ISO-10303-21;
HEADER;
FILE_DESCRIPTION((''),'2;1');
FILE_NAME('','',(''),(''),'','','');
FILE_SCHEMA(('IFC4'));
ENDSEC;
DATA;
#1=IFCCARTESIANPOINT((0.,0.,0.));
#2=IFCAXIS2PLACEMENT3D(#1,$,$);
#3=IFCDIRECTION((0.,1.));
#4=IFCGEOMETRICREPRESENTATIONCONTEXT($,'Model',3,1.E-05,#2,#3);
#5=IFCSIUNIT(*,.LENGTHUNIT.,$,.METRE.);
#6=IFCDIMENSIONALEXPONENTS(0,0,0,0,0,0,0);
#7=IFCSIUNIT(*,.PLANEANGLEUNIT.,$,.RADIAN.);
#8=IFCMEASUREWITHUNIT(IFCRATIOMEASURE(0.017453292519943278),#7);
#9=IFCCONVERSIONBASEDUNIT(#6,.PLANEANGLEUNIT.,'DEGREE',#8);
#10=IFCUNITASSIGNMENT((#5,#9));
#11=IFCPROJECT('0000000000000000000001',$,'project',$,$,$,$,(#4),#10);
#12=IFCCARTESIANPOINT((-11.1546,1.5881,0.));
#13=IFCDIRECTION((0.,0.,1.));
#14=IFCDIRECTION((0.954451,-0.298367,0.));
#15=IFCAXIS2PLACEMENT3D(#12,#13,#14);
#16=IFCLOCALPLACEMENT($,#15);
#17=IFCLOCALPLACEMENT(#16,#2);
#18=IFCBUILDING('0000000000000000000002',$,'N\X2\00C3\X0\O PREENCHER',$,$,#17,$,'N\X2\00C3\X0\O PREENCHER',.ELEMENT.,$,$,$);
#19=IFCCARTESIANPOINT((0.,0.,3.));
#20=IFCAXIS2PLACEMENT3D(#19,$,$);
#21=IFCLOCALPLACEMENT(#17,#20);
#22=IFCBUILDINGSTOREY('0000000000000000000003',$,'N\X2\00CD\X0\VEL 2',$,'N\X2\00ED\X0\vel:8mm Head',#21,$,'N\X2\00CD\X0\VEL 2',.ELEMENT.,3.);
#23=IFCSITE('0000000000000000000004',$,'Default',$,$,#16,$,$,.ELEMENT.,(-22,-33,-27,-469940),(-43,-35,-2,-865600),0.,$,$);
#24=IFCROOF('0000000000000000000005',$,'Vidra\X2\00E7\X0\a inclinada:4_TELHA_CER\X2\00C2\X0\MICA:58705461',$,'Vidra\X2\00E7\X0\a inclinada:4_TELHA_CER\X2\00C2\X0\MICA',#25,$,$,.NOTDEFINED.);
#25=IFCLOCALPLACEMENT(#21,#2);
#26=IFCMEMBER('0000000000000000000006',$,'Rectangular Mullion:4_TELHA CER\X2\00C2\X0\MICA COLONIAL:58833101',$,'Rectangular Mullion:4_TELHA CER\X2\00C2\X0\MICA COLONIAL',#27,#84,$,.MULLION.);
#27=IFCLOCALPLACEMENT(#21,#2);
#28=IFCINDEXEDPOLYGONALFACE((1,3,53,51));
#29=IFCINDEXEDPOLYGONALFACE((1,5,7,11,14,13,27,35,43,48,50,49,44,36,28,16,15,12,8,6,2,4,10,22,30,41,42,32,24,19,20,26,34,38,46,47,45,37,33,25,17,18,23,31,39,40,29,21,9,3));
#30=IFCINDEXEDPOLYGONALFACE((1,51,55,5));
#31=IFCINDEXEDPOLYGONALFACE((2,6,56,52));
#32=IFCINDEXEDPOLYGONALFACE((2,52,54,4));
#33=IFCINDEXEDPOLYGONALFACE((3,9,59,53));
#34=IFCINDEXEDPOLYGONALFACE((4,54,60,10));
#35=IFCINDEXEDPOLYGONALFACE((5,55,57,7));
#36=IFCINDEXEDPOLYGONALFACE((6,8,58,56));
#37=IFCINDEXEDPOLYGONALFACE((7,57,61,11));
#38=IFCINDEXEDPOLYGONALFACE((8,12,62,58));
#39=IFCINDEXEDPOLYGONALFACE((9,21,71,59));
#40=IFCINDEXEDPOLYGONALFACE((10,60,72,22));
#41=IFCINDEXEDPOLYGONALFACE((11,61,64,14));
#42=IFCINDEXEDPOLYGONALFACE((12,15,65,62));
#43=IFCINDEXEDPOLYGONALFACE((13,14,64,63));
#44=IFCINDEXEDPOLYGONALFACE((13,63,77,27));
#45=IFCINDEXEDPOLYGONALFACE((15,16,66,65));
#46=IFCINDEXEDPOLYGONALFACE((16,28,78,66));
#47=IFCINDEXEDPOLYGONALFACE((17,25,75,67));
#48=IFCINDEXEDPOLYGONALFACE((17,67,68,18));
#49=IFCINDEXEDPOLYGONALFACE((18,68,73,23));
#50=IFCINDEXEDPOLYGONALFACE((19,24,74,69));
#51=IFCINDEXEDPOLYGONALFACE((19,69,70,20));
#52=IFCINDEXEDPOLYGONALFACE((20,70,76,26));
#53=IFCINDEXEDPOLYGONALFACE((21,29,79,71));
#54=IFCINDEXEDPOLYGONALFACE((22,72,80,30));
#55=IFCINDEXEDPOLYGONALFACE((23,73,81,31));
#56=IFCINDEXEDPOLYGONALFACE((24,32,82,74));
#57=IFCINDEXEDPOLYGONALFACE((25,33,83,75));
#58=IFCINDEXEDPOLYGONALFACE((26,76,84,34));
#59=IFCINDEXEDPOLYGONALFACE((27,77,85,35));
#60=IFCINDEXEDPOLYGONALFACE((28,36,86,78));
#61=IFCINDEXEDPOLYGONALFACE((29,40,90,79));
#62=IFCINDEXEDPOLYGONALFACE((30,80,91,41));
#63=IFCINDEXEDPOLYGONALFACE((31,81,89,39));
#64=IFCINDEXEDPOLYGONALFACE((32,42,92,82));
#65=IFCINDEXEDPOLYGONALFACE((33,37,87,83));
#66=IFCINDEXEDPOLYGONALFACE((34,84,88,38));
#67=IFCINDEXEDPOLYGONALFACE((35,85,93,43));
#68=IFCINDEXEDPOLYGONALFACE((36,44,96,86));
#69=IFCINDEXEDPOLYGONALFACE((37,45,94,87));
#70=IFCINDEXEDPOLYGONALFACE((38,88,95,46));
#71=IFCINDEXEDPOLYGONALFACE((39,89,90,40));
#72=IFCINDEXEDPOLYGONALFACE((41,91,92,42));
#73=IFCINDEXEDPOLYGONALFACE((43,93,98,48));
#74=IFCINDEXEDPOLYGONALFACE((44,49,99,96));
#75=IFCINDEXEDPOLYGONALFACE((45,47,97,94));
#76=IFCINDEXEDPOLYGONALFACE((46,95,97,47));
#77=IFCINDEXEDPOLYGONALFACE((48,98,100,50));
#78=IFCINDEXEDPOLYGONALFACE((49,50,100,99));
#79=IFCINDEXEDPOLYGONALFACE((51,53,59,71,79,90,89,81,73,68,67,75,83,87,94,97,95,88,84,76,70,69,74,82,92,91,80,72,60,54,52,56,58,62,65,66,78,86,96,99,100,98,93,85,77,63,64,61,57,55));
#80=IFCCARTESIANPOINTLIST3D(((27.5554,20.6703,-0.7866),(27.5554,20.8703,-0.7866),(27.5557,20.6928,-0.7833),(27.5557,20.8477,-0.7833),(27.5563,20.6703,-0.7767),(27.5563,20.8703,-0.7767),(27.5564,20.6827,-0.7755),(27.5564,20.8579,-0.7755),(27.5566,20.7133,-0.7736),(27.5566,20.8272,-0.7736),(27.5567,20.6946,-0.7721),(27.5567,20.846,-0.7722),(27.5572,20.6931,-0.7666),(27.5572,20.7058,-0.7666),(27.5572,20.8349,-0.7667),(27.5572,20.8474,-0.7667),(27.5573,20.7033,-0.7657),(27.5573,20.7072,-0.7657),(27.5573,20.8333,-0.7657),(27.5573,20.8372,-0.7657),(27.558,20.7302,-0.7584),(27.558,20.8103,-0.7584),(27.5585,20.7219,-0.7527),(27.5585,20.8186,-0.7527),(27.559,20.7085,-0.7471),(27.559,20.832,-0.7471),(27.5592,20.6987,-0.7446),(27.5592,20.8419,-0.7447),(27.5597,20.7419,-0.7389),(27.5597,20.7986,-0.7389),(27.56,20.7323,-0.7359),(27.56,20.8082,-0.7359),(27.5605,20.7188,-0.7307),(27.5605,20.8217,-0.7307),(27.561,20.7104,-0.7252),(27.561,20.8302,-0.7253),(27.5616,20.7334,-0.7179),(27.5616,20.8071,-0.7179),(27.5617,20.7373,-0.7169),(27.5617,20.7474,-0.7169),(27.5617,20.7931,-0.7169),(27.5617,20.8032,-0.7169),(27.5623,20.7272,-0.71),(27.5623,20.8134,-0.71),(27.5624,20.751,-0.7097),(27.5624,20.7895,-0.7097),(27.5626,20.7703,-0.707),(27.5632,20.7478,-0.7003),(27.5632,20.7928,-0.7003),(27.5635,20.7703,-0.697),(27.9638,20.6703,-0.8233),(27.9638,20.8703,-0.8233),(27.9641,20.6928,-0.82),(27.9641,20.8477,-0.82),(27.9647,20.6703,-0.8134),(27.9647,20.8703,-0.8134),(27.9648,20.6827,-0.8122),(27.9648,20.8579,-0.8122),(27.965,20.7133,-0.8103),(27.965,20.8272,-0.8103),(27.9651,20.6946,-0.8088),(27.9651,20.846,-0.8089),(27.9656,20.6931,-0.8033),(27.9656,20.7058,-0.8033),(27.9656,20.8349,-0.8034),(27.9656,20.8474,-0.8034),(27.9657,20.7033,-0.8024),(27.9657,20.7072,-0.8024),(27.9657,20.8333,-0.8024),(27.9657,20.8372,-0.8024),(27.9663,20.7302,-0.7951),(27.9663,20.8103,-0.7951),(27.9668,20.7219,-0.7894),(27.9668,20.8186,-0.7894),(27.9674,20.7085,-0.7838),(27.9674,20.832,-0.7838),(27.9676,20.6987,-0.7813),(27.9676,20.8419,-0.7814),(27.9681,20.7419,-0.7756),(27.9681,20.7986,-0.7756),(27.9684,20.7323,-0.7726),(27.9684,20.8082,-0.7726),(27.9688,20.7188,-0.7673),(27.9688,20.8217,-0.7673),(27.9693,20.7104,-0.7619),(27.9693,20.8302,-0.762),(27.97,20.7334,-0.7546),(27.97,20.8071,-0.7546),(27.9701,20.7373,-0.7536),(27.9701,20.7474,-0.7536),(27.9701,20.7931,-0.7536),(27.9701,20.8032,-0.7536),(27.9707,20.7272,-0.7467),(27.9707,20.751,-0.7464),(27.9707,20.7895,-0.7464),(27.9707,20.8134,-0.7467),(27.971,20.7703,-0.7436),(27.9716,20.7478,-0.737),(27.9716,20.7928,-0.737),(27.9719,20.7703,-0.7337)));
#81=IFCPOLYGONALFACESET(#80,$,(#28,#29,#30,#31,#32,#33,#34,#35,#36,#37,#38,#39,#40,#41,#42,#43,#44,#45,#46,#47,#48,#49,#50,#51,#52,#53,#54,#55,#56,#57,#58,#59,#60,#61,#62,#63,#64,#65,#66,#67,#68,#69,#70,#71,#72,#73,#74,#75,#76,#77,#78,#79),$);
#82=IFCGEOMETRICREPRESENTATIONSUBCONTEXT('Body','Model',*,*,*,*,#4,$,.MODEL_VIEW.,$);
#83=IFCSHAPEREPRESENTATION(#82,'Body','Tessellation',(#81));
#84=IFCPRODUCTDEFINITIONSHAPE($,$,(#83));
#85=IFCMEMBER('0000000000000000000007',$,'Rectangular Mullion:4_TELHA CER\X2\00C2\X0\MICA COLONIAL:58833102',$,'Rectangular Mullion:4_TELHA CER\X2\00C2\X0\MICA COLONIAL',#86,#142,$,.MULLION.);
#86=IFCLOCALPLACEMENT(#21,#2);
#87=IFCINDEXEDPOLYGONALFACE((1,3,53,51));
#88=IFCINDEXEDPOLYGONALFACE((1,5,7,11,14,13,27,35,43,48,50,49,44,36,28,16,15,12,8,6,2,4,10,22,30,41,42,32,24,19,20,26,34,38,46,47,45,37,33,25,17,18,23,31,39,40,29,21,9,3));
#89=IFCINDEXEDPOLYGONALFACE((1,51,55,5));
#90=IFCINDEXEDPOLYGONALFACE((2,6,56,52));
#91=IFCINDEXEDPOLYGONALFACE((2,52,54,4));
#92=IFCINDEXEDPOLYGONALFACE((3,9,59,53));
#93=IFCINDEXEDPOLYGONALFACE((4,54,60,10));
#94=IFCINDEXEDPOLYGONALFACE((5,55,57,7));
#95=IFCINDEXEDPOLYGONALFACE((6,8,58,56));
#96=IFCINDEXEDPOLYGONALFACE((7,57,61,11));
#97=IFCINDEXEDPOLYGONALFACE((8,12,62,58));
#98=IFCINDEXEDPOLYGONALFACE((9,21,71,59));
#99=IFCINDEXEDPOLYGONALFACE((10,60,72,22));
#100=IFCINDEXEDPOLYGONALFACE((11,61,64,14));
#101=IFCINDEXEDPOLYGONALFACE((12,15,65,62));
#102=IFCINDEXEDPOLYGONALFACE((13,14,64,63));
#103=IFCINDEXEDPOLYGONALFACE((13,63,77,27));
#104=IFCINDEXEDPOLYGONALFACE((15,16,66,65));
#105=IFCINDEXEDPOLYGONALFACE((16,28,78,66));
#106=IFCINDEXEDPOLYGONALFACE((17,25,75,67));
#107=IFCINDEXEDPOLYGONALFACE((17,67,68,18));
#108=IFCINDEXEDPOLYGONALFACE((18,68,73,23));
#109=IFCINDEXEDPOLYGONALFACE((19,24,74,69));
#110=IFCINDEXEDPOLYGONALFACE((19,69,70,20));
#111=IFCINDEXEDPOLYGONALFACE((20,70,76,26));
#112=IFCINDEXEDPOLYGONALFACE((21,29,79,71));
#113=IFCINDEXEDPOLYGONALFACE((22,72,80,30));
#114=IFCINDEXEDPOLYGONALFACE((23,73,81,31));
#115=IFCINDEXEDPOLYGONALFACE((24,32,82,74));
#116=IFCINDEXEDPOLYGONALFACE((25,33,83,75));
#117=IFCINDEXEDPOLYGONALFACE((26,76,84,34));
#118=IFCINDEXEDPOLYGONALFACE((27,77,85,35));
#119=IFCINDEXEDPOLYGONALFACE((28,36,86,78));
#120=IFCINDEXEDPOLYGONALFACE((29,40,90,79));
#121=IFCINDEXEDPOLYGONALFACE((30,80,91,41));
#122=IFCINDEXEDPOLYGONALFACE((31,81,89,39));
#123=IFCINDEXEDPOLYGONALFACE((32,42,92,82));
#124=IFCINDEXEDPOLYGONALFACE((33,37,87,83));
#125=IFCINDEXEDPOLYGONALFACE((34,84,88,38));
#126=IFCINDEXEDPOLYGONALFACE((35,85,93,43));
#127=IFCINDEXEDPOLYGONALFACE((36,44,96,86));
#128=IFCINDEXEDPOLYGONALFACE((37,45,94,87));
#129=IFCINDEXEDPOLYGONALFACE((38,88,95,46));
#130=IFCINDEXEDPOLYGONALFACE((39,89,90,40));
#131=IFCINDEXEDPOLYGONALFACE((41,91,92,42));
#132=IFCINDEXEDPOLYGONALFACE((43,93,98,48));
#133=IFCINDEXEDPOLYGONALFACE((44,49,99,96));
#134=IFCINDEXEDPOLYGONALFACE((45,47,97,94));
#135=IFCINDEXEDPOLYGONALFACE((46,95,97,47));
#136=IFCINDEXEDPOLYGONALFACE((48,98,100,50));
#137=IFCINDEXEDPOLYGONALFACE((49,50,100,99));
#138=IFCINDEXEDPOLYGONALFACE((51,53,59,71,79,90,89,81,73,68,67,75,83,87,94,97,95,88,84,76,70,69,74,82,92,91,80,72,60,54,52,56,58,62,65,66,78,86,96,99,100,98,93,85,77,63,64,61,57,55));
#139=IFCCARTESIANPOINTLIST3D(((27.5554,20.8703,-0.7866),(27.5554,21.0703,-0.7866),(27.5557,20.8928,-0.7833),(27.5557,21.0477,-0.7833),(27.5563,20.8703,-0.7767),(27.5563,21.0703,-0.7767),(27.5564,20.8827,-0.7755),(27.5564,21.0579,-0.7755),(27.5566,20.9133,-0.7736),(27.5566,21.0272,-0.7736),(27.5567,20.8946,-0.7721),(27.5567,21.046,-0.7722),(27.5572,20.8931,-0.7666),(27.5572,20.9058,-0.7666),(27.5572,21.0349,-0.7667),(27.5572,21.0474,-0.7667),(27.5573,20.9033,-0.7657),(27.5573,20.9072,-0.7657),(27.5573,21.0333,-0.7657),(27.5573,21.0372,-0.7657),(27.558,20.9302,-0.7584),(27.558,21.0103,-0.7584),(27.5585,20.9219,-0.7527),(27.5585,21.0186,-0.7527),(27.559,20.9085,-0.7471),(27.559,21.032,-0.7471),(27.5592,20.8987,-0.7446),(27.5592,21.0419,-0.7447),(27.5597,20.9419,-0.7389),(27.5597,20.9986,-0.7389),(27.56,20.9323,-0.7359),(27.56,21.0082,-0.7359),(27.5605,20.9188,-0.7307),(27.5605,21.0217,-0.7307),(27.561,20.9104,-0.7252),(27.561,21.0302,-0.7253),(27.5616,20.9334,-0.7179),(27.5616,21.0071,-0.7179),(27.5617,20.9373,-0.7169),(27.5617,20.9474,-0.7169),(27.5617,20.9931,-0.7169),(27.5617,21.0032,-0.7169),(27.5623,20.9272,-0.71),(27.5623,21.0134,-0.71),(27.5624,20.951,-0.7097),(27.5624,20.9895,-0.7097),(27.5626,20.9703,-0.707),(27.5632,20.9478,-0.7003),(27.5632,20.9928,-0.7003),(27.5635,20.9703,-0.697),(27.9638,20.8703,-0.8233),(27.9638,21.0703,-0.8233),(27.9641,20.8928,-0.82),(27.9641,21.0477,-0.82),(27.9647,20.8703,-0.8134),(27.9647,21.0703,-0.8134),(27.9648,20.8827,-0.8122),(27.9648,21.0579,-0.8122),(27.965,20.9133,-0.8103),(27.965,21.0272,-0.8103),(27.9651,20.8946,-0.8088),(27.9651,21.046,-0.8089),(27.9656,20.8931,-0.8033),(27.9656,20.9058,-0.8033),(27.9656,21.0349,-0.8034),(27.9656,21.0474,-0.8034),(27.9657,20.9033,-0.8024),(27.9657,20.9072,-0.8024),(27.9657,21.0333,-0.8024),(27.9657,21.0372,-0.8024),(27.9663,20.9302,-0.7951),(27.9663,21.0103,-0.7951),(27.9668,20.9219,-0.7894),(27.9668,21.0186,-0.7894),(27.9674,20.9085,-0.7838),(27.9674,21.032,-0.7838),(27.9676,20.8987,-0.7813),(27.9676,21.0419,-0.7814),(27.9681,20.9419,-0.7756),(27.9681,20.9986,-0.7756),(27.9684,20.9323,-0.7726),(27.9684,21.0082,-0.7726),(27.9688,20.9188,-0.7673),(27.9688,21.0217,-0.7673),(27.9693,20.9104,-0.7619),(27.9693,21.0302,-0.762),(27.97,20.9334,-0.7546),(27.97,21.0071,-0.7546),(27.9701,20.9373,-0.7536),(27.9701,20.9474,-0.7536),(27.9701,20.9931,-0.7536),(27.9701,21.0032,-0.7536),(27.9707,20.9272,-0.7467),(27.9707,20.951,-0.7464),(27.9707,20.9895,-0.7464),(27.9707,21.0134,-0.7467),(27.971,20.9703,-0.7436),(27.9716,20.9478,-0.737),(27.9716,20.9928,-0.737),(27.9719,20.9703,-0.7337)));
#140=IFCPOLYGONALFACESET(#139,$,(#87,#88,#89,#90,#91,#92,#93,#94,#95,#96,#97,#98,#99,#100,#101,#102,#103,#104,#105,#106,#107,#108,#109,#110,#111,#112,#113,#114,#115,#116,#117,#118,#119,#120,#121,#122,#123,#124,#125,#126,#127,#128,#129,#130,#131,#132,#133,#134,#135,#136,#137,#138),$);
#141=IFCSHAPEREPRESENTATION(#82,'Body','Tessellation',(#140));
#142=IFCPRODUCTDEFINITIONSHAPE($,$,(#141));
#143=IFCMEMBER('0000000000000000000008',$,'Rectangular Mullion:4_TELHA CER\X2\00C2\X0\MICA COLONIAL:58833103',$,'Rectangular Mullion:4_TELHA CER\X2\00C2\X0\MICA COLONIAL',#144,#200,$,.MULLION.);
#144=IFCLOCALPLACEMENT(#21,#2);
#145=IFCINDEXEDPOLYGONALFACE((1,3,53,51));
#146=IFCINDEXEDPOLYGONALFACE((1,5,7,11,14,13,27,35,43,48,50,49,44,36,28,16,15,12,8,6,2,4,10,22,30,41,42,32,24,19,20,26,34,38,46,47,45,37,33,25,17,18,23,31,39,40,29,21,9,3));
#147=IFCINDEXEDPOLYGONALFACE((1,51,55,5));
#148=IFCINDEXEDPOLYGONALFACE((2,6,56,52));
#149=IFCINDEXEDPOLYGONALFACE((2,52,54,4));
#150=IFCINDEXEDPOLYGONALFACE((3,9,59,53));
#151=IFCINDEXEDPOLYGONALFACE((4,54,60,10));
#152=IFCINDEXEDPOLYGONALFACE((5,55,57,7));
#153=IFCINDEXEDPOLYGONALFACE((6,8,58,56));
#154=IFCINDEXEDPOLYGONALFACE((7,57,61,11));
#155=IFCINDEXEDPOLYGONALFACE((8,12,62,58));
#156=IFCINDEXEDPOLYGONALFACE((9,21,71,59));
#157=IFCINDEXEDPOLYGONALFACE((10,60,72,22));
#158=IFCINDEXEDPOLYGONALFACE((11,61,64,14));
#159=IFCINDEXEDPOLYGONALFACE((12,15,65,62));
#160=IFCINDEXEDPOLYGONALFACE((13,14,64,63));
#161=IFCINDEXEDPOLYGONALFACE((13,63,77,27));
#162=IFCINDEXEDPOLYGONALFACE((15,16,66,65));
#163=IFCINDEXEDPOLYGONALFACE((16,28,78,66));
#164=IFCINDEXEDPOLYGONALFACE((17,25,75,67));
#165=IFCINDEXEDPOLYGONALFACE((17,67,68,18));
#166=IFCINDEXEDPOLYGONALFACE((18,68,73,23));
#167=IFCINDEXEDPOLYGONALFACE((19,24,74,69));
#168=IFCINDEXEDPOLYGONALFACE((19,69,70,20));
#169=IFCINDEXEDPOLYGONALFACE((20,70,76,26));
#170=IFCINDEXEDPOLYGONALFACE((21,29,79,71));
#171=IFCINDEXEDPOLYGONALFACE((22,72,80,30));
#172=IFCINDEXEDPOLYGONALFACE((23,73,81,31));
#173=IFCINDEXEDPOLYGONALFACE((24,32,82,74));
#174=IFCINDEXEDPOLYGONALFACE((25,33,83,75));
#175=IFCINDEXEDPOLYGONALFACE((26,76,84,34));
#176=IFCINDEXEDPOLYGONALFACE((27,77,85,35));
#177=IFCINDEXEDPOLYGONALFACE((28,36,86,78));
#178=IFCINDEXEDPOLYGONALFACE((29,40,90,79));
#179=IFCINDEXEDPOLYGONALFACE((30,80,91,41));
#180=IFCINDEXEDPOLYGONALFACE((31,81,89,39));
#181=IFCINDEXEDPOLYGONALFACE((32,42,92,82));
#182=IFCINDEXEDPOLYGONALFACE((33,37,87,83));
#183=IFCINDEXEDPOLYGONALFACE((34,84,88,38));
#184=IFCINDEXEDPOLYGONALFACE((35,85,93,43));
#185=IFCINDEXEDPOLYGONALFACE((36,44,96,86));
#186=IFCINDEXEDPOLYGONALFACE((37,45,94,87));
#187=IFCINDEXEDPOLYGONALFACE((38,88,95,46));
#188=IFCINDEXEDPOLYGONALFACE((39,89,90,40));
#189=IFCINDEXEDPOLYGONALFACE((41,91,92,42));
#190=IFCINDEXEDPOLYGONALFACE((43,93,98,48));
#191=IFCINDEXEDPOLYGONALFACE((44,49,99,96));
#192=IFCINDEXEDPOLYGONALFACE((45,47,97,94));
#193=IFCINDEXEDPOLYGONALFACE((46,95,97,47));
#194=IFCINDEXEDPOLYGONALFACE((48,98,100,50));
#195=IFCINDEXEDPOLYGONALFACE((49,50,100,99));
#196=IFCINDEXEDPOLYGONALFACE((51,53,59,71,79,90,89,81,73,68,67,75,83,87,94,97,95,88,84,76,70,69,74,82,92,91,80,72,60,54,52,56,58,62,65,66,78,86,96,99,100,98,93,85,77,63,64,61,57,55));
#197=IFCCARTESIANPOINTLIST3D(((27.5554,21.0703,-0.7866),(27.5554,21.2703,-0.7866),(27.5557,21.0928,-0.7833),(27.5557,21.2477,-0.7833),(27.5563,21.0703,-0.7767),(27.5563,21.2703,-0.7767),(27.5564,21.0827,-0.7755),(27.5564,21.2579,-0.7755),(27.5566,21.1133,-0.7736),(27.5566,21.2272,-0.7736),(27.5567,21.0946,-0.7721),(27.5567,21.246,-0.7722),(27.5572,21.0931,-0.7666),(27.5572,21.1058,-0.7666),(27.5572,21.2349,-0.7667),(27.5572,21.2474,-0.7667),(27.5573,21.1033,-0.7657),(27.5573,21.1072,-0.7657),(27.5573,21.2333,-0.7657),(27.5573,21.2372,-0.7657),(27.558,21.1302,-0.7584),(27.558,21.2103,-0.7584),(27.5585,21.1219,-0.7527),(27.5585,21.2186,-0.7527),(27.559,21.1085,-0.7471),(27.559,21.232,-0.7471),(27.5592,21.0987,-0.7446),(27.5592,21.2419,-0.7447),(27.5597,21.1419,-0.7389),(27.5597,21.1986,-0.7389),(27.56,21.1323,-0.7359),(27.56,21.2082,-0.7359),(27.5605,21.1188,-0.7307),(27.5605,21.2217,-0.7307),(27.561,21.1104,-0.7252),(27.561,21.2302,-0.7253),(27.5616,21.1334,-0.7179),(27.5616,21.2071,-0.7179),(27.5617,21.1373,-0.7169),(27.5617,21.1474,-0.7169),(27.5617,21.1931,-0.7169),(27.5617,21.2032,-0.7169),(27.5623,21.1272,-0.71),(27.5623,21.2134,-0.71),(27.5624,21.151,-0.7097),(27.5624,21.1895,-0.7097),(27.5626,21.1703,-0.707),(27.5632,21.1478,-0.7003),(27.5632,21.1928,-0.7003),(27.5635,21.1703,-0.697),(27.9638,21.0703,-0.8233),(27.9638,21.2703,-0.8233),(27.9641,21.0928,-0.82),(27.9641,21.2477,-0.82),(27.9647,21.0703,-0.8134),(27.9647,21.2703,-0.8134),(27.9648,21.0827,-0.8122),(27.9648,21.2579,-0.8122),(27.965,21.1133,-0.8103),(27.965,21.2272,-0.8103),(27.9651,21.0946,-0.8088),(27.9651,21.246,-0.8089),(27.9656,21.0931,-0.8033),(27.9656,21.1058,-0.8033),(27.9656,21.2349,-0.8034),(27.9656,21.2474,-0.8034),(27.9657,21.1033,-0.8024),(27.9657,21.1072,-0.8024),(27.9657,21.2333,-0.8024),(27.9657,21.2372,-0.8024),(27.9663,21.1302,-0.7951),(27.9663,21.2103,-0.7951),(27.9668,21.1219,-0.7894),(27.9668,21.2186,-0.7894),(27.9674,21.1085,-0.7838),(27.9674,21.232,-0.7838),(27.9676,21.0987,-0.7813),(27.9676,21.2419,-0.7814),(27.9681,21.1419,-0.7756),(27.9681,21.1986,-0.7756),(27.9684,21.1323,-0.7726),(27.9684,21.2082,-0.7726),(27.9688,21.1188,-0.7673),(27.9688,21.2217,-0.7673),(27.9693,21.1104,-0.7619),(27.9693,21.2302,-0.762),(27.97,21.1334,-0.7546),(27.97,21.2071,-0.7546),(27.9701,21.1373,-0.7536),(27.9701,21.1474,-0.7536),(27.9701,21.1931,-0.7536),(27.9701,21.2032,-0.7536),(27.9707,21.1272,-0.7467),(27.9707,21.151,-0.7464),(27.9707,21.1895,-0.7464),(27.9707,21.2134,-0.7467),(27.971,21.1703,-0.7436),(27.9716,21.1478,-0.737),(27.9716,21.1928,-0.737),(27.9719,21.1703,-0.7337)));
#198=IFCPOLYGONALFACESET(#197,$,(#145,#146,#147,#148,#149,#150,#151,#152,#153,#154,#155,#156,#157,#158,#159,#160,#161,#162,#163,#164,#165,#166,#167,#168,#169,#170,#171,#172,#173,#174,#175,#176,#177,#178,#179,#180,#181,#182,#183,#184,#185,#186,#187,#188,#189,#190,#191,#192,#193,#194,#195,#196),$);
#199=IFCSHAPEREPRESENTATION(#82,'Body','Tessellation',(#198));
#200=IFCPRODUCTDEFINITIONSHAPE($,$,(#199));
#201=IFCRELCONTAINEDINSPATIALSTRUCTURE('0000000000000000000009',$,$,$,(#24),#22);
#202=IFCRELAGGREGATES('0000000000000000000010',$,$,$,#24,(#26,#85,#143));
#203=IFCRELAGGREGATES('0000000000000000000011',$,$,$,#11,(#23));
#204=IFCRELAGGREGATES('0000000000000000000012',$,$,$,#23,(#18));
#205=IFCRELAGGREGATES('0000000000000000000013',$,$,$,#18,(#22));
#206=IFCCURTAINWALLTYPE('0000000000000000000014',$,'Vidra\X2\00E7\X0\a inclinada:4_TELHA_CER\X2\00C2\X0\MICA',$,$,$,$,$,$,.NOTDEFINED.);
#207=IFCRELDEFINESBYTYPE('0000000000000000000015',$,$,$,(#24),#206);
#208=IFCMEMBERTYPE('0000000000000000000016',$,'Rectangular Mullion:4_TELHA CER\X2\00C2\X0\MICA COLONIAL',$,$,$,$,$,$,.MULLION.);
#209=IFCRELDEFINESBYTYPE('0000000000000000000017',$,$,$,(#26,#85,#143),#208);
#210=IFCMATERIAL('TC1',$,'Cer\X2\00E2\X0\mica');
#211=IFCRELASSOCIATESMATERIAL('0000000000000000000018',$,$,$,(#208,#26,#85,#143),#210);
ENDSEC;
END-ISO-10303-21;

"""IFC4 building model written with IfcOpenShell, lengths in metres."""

from ifc_helpers import new_model, entity, si_unit, converted_unit, direction, frame, origin, place, context, subcontext, project, spatial, line, arc, indexed_curve, outline, extrude, source, transform, mapped, material, type_object, type_shapes, element, aggregate, save


model = new_model("IFC4")

# Units and contexts
model_context = context("Model", 3, precision=1e-05, world=origin(), true_north=direction((0.0, 1.0)))
body_context = subcontext(model_context, "Body", "Model", "MODEL_VIEW")
ifc_project = project(units=[si_unit("LENGTHUNIT", "METRE"), converted_unit("PLANEANGLEUNIT", "DEGREE", entity("IfcRatioMeasure", 0.017453292519943278), si_unit("PLANEANGLEUNIT", "RADIAN"), dimensions=[0, 0, 0, 0, 0, 0, 0])], contexts=[model_context])

# Site, building, storey
site_placement = place(None, frame((-11.1546, 1.5881, 0.0), z_axis=(0.0, 0.0, 1.0), x_axis=(0.954451, -0.298367, 0.0)))
site = spatial("IfcSite", under=ifc_project, at=site_placement, Name="Default", CompositionType="ELEMENT", RefLatitude=(-22, -33, -27, -469940), RefLongitude=(-43, -35, -2, -865600), RefElevation=0.0)
building_placement = place(site_placement, origin())
building = spatial("IfcBuilding", under=site, at=building_placement, Name="NÃO PREENCHER", LongName="NÃO PREENCHER", CompositionType="ELEMENT")
storey_placement = place(building_placement, frame((0.0, 0.0, 3.0)))
storey = spatial("IfcBuildingStorey", under=building, at=storey_placement, Name="NÍVEL 2", ObjectType="Nível:8mm Head", LongName="NÍVEL 2", CompositionType="ELEMENT", Elevation=3.0)

# Roof, members
curtain_wall_type = type_object("IfcCurtainWallType", Name="Vidraça inclinada:4_TELHA_CERÂMICA", PredefinedType="NOTDEFINED")
roof_placement = place(storey_placement, frame((0.0, 0.0, -3.0)))
roof = element("IfcRoof", 1, at=roof_placement, inside=storey, type_object=curtain_wall_type, Name="Vidraça inclinada:4_TELHA_CERÂMICA:58705461", ObjectType="Vidraça inclinada:4_TELHA_CERÂMICA", PredefinedType="NOTDEFINED")
ifc_material = material(Name="TC1", Category="Cerâmica")
member_type_1 = type_object("IfcMemberType", Name="Rectangular Mullion:4_TELHA CERÂMICA COLONIAL", PredefinedType="MULLION", material=ifc_material)
shared_shape_1 = source(origin(), body_context, "Body", "SweptSolid", [
    extrude(outline(indexed_curve([(-0.029, -0.1), (-0.019, -0.1), (-0.0164, -0.0815), (-0.0089, -0.0645), (-0.0089, -0.0771), (0.061, 0.0), (-0.009, 0.0771), (-0.009, 0.0646), (-0.0165, 0.0816), (-0.019, 0.1), (-0.029, 0.1), (-0.0089, 0.0479), (0.041, 0.0229), (0.041, 0.0329), (0.0131, 0.0425), (-0.008, 0.0631), (-0.008, 0.067), (0.051, 0.0), (-0.008, -0.067), (-0.008, -0.0631), (0.0131, -0.0425), (0.041, -0.0329), (0.041, -0.0229), (-0.0089, -0.0479)], segments=[line(1, 2), arc(2, 3, 4), line(4, 5), arc(5, 6, 7), line(7, 8), arc(8, 9, 10), line(10, 11), arc(11, 12, 13), line(13, 14), arc(14, 15, 16), line(16, 17), arc(17, 18, 19), line(19, 20), arc(20, 21, 22), line(22, 23), arc(23, 24, 1)], self_intersect=False)), frame((0.0, -0.029, -0.41), z_axis=(0.0, 0.0, 1.0), x_axis=(0.0, -1.0, 0.0)), (0.0, 0.0, 1.0), 0.41),
])
type_shapes(member_type_1, [shared_shape_1])
member_1_placement = place(roof_placement, frame((27.5554, 20.7703, 2.2134), z_axis=(-0.99599, 0.0, 0.089469), x_axis=(0.0, 1.0, 0.0)))
member_1 = element("IfcMember", 2, at=member_1_placement, type_object=member_type_1, material=ifc_material, Name="Rectangular Mullion:4_TELHA CERÂMICA COLONIAL:58833101", ObjectType="Rectangular Mullion:4_TELHA CERÂMICA COLONIAL", PredefinedType="MULLION", context=body_context, shape_type="MappedRepresentation", body=[
    mapped(shared_shape_1, transform((0.0, 0.0, 0.0), scale=1.0)),
])
member_2_placement = place(roof_placement, frame((27.5554, 20.9703, 2.2134), z_axis=(-0.99599, 0.0, 0.089469), x_axis=(0.0, 1.0, 0.0)))
member_2 = element("IfcMember", 3, at=member_2_placement, type_object=member_type_1, material=ifc_material, Name="Rectangular Mullion:4_TELHA CERÂMICA COLONIAL:58833102", ObjectType="Rectangular Mullion:4_TELHA CERÂMICA COLONIAL", PredefinedType="MULLION", context=body_context, shape_type="MappedRepresentation", body=[
    mapped(shared_shape_1, transform((0.0, 0.0, 0.0), scale=1.0)),
])
member_3_placement = place(roof_placement, frame((27.5554, 21.1703, 2.2134), z_axis=(-0.99599, 0.0, 0.089469), x_axis=(0.0, 1.0, 0.0)))
member_3 = element("IfcMember", 4, at=member_3_placement, type_object=member_type_1, material=ifc_material, Name="Rectangular Mullion:4_TELHA CERÂMICA COLONIAL:58833103", ObjectType="Rectangular Mullion:4_TELHA CERÂMICA COLONIAL", PredefinedType="MULLION", context=body_context, shape_type="MappedRepresentation", body=[
    mapped(shared_shape_1, transform((0.0, 0.0, 0.0), scale=1.0)),
])
aggregate(roof, [member_1, member_2, member_3])

save(model, "model.ifc")
